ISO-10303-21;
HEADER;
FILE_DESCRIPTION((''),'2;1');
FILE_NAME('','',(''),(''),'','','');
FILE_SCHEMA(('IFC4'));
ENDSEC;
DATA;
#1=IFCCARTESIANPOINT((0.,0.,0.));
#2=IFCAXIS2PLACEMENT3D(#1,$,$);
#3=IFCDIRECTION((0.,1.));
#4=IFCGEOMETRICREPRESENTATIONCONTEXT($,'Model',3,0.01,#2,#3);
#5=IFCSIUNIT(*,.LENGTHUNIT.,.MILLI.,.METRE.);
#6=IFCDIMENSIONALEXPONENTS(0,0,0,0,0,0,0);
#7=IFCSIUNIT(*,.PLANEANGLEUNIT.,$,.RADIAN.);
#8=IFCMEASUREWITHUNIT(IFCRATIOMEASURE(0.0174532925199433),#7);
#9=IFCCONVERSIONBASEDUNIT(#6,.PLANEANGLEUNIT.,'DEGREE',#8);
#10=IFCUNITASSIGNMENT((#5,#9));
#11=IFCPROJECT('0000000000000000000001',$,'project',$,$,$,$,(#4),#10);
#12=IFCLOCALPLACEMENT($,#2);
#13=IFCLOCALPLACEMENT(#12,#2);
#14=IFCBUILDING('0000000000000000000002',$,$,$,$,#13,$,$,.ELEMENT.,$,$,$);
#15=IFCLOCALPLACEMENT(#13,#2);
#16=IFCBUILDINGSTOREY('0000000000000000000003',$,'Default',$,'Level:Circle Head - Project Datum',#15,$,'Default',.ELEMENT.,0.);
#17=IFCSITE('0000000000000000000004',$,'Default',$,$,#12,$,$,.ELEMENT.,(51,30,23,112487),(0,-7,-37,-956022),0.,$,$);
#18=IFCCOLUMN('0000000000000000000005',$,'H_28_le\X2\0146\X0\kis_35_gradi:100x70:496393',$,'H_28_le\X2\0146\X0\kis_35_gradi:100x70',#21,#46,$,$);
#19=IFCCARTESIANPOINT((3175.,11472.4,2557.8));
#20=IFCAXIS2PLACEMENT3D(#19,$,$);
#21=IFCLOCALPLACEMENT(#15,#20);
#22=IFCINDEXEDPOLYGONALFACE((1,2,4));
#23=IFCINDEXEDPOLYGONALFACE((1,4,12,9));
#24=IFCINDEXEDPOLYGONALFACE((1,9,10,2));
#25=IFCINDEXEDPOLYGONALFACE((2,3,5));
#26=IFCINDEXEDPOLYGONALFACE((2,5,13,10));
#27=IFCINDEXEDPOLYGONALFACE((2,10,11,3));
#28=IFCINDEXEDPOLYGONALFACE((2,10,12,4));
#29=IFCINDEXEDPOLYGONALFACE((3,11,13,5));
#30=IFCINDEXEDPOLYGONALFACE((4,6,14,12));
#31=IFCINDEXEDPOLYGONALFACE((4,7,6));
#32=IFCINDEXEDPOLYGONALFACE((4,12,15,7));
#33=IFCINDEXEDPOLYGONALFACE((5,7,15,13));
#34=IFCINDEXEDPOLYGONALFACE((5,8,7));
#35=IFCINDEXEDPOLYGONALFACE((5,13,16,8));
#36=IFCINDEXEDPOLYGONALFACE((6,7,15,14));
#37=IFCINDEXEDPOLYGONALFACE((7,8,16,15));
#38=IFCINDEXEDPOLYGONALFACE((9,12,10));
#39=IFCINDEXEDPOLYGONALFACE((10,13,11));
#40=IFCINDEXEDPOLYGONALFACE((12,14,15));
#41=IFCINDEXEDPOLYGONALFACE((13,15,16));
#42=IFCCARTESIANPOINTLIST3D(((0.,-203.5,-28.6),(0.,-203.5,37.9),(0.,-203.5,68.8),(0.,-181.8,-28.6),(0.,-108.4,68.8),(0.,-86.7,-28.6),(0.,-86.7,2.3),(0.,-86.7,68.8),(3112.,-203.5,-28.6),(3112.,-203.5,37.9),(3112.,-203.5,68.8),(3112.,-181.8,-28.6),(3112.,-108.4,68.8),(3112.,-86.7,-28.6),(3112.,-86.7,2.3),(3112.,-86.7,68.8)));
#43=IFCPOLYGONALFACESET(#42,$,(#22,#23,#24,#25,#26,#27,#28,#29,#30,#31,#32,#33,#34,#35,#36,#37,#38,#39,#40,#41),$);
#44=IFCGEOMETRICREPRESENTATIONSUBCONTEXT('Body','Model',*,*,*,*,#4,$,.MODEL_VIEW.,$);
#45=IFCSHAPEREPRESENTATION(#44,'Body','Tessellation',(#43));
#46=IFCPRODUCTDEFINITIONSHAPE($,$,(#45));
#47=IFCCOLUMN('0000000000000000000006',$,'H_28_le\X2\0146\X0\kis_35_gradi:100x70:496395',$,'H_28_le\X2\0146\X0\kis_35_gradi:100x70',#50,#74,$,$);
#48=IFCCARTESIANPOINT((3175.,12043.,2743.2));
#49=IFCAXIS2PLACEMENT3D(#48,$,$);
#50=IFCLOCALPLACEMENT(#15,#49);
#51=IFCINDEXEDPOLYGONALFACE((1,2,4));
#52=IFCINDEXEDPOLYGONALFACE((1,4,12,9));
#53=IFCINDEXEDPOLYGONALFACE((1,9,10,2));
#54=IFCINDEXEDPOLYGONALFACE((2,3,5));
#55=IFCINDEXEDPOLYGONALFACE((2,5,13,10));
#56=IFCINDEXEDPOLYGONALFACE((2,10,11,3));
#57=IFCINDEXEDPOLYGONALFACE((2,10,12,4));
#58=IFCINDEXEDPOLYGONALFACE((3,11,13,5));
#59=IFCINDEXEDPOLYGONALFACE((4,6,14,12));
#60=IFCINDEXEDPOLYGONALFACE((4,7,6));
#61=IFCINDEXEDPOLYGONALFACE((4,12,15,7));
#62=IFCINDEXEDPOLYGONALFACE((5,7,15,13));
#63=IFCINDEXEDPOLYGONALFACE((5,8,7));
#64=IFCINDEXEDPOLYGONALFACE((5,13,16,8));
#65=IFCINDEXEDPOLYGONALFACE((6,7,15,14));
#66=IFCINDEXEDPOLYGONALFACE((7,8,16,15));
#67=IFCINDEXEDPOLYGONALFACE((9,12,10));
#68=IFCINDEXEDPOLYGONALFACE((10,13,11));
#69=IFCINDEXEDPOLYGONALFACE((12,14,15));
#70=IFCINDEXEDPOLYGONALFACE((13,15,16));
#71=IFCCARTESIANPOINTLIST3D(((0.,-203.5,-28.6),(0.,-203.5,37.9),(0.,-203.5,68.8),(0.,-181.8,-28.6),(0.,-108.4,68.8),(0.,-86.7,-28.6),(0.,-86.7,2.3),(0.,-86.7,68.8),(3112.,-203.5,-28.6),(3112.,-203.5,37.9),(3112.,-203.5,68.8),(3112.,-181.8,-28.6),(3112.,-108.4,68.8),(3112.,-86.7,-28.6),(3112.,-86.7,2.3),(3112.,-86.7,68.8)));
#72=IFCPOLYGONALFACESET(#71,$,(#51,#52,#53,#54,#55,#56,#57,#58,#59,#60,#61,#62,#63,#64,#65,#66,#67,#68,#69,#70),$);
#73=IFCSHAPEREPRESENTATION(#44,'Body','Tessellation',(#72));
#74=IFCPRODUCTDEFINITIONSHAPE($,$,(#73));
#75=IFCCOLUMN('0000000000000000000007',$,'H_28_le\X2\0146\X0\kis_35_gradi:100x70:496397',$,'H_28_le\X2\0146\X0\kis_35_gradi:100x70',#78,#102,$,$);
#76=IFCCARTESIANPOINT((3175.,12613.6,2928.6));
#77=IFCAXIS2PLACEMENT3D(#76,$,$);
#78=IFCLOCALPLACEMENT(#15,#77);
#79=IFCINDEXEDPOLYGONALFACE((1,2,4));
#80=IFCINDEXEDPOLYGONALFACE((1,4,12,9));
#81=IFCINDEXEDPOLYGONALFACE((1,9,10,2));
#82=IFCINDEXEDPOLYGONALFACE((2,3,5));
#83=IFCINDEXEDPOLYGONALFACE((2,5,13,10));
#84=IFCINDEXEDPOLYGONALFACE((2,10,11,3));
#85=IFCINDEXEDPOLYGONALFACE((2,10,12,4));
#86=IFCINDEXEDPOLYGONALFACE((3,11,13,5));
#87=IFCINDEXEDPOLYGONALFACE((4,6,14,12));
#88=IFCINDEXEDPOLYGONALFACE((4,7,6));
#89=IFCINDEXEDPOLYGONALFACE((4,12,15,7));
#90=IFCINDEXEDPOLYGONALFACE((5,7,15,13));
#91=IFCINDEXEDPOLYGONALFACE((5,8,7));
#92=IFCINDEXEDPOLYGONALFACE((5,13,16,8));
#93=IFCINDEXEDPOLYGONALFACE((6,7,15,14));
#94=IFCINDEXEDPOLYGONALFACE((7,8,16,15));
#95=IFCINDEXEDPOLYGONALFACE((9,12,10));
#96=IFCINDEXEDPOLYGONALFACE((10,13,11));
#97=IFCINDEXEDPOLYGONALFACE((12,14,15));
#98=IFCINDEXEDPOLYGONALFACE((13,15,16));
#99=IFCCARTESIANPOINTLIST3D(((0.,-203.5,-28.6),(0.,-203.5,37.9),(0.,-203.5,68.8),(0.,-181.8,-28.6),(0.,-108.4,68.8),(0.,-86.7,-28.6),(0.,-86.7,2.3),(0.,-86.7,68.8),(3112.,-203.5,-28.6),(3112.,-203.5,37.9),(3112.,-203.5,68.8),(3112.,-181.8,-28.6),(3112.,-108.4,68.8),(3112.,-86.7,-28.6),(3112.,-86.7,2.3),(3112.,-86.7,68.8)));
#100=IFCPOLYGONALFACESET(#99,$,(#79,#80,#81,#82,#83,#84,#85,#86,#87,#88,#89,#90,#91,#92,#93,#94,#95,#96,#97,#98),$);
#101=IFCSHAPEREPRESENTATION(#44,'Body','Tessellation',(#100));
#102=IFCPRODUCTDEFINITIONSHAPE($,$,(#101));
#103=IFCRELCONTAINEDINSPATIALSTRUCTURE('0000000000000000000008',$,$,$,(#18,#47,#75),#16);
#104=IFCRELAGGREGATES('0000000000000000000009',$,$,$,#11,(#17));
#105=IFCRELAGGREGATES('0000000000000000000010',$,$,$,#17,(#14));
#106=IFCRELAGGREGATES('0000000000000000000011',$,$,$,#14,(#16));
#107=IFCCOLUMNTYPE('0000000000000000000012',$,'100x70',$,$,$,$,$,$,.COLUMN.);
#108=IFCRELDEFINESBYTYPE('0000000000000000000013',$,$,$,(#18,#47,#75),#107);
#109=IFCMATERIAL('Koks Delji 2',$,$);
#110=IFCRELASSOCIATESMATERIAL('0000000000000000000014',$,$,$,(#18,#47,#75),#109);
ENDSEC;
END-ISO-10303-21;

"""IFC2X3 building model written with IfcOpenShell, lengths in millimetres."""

from ifc_helpers import new_model, entity, si_unit, converted_unit, direction, frame, frame_2d, origin, origin_2d_with_axis, place, context, subcontext, project, spatial, rectangle, extrude, boolean, source, transform, mapped, material, type_object, type_shapes, element, save


model = new_model("IFC2X3")

# Units and contexts
model_context = context("Model", 3, precision=0.01, world=origin(), true_north=direction((0.0, 1.0)))
body_context = subcontext(model_context, "Body", "Model", "MODEL_VIEW")
ifc_project = project(units=[si_unit("LENGTHUNIT", "METRE", prefix="MILLI"), converted_unit("PLANEANGLEUNIT", "DEGREE", entity("IfcRatioMeasure", 0.0174532925199433), si_unit("PLANEANGLEUNIT", "RADIAN"), dimensions=[0, 0, 0, 0, 0, 0, 0])], contexts=[model_context])

# Site, building, storey
site_placement = place(None, origin())
site = spatial("IfcSite", under=ifc_project, at=site_placement, Name="Default", CompositionType="ELEMENT", RefLatitude=(51, 30, 23, 112487), RefLongitude=(0, -7, -37, -956022), RefElevation=0.0)
building_placement = place(site_placement, origin())
building = spatial("IfcBuilding", under=site, at=building_placement, CompositionType="ELEMENT")
storey_placement = place(building_placement, origin())
storey = spatial("IfcBuildingStorey", under=building, at=storey_placement, Name="Default", ObjectType="Level:Circle Head - Project Datum", LongName="Default", CompositionType="ELEMENT", Elevation=0.0)

# Columns
ifc_material_1 = material(Name="Koks Delji 2")
column_type_1 = type_object("IfcColumnType", Name="100x70", PredefinedType="COLUMN")
shared_shape_1 = source(origin(), body_context, "Body", "CSG", [
    boolean("DIFFERENCE", extrude(rectangle(XDim=3112.0, YDim=116.7, at=origin_2d_with_axis()), frame((1556.0, -145.1, -28.6)), (0.0, 0.0, 1.0), 97.5), extrude(rectangle(XDim=70.0, YDim=100.0, at=frame_2d((0.0, 0.0), x_axis=(0.0, 1.0))), frame((0.0, -145.1, 20.1), z_axis=(-1.0, 0.0, 0.0), x_axis=(0.0, -0.951057, -0.309017)), (0.0, 0.0, -1.0), 3112.0)),
])
type_shapes(column_type_1, [shared_shape_1])
for number, where, name in (
    (1, (3175.0, 11472.4, 2557.8), "H_28_leņkis_35_gradi:100x70:496393"),
    (2, (3175.0, 12043.0, 2743.2), "H_28_leņkis_35_gradi:100x70:496395"),
    (3, (3175.0, 12613.6, 2928.6), "H_28_leņkis_35_gradi:100x70:496397"),
):
    element("IfcColumn", number, at=place(storey_placement, frame(where)), inside=storey, type_object=column_type_1, material=ifc_material_1, Name=name, ObjectType="H_28_leņkis_35_gradi:100x70", context=body_context, shape_type="MappedRepresentation", body=[
        mapped(shared_shape_1, transform((0.0, 0.0, 0.0), scale=1.0)),
    ])

save(model, "model.ifc")
